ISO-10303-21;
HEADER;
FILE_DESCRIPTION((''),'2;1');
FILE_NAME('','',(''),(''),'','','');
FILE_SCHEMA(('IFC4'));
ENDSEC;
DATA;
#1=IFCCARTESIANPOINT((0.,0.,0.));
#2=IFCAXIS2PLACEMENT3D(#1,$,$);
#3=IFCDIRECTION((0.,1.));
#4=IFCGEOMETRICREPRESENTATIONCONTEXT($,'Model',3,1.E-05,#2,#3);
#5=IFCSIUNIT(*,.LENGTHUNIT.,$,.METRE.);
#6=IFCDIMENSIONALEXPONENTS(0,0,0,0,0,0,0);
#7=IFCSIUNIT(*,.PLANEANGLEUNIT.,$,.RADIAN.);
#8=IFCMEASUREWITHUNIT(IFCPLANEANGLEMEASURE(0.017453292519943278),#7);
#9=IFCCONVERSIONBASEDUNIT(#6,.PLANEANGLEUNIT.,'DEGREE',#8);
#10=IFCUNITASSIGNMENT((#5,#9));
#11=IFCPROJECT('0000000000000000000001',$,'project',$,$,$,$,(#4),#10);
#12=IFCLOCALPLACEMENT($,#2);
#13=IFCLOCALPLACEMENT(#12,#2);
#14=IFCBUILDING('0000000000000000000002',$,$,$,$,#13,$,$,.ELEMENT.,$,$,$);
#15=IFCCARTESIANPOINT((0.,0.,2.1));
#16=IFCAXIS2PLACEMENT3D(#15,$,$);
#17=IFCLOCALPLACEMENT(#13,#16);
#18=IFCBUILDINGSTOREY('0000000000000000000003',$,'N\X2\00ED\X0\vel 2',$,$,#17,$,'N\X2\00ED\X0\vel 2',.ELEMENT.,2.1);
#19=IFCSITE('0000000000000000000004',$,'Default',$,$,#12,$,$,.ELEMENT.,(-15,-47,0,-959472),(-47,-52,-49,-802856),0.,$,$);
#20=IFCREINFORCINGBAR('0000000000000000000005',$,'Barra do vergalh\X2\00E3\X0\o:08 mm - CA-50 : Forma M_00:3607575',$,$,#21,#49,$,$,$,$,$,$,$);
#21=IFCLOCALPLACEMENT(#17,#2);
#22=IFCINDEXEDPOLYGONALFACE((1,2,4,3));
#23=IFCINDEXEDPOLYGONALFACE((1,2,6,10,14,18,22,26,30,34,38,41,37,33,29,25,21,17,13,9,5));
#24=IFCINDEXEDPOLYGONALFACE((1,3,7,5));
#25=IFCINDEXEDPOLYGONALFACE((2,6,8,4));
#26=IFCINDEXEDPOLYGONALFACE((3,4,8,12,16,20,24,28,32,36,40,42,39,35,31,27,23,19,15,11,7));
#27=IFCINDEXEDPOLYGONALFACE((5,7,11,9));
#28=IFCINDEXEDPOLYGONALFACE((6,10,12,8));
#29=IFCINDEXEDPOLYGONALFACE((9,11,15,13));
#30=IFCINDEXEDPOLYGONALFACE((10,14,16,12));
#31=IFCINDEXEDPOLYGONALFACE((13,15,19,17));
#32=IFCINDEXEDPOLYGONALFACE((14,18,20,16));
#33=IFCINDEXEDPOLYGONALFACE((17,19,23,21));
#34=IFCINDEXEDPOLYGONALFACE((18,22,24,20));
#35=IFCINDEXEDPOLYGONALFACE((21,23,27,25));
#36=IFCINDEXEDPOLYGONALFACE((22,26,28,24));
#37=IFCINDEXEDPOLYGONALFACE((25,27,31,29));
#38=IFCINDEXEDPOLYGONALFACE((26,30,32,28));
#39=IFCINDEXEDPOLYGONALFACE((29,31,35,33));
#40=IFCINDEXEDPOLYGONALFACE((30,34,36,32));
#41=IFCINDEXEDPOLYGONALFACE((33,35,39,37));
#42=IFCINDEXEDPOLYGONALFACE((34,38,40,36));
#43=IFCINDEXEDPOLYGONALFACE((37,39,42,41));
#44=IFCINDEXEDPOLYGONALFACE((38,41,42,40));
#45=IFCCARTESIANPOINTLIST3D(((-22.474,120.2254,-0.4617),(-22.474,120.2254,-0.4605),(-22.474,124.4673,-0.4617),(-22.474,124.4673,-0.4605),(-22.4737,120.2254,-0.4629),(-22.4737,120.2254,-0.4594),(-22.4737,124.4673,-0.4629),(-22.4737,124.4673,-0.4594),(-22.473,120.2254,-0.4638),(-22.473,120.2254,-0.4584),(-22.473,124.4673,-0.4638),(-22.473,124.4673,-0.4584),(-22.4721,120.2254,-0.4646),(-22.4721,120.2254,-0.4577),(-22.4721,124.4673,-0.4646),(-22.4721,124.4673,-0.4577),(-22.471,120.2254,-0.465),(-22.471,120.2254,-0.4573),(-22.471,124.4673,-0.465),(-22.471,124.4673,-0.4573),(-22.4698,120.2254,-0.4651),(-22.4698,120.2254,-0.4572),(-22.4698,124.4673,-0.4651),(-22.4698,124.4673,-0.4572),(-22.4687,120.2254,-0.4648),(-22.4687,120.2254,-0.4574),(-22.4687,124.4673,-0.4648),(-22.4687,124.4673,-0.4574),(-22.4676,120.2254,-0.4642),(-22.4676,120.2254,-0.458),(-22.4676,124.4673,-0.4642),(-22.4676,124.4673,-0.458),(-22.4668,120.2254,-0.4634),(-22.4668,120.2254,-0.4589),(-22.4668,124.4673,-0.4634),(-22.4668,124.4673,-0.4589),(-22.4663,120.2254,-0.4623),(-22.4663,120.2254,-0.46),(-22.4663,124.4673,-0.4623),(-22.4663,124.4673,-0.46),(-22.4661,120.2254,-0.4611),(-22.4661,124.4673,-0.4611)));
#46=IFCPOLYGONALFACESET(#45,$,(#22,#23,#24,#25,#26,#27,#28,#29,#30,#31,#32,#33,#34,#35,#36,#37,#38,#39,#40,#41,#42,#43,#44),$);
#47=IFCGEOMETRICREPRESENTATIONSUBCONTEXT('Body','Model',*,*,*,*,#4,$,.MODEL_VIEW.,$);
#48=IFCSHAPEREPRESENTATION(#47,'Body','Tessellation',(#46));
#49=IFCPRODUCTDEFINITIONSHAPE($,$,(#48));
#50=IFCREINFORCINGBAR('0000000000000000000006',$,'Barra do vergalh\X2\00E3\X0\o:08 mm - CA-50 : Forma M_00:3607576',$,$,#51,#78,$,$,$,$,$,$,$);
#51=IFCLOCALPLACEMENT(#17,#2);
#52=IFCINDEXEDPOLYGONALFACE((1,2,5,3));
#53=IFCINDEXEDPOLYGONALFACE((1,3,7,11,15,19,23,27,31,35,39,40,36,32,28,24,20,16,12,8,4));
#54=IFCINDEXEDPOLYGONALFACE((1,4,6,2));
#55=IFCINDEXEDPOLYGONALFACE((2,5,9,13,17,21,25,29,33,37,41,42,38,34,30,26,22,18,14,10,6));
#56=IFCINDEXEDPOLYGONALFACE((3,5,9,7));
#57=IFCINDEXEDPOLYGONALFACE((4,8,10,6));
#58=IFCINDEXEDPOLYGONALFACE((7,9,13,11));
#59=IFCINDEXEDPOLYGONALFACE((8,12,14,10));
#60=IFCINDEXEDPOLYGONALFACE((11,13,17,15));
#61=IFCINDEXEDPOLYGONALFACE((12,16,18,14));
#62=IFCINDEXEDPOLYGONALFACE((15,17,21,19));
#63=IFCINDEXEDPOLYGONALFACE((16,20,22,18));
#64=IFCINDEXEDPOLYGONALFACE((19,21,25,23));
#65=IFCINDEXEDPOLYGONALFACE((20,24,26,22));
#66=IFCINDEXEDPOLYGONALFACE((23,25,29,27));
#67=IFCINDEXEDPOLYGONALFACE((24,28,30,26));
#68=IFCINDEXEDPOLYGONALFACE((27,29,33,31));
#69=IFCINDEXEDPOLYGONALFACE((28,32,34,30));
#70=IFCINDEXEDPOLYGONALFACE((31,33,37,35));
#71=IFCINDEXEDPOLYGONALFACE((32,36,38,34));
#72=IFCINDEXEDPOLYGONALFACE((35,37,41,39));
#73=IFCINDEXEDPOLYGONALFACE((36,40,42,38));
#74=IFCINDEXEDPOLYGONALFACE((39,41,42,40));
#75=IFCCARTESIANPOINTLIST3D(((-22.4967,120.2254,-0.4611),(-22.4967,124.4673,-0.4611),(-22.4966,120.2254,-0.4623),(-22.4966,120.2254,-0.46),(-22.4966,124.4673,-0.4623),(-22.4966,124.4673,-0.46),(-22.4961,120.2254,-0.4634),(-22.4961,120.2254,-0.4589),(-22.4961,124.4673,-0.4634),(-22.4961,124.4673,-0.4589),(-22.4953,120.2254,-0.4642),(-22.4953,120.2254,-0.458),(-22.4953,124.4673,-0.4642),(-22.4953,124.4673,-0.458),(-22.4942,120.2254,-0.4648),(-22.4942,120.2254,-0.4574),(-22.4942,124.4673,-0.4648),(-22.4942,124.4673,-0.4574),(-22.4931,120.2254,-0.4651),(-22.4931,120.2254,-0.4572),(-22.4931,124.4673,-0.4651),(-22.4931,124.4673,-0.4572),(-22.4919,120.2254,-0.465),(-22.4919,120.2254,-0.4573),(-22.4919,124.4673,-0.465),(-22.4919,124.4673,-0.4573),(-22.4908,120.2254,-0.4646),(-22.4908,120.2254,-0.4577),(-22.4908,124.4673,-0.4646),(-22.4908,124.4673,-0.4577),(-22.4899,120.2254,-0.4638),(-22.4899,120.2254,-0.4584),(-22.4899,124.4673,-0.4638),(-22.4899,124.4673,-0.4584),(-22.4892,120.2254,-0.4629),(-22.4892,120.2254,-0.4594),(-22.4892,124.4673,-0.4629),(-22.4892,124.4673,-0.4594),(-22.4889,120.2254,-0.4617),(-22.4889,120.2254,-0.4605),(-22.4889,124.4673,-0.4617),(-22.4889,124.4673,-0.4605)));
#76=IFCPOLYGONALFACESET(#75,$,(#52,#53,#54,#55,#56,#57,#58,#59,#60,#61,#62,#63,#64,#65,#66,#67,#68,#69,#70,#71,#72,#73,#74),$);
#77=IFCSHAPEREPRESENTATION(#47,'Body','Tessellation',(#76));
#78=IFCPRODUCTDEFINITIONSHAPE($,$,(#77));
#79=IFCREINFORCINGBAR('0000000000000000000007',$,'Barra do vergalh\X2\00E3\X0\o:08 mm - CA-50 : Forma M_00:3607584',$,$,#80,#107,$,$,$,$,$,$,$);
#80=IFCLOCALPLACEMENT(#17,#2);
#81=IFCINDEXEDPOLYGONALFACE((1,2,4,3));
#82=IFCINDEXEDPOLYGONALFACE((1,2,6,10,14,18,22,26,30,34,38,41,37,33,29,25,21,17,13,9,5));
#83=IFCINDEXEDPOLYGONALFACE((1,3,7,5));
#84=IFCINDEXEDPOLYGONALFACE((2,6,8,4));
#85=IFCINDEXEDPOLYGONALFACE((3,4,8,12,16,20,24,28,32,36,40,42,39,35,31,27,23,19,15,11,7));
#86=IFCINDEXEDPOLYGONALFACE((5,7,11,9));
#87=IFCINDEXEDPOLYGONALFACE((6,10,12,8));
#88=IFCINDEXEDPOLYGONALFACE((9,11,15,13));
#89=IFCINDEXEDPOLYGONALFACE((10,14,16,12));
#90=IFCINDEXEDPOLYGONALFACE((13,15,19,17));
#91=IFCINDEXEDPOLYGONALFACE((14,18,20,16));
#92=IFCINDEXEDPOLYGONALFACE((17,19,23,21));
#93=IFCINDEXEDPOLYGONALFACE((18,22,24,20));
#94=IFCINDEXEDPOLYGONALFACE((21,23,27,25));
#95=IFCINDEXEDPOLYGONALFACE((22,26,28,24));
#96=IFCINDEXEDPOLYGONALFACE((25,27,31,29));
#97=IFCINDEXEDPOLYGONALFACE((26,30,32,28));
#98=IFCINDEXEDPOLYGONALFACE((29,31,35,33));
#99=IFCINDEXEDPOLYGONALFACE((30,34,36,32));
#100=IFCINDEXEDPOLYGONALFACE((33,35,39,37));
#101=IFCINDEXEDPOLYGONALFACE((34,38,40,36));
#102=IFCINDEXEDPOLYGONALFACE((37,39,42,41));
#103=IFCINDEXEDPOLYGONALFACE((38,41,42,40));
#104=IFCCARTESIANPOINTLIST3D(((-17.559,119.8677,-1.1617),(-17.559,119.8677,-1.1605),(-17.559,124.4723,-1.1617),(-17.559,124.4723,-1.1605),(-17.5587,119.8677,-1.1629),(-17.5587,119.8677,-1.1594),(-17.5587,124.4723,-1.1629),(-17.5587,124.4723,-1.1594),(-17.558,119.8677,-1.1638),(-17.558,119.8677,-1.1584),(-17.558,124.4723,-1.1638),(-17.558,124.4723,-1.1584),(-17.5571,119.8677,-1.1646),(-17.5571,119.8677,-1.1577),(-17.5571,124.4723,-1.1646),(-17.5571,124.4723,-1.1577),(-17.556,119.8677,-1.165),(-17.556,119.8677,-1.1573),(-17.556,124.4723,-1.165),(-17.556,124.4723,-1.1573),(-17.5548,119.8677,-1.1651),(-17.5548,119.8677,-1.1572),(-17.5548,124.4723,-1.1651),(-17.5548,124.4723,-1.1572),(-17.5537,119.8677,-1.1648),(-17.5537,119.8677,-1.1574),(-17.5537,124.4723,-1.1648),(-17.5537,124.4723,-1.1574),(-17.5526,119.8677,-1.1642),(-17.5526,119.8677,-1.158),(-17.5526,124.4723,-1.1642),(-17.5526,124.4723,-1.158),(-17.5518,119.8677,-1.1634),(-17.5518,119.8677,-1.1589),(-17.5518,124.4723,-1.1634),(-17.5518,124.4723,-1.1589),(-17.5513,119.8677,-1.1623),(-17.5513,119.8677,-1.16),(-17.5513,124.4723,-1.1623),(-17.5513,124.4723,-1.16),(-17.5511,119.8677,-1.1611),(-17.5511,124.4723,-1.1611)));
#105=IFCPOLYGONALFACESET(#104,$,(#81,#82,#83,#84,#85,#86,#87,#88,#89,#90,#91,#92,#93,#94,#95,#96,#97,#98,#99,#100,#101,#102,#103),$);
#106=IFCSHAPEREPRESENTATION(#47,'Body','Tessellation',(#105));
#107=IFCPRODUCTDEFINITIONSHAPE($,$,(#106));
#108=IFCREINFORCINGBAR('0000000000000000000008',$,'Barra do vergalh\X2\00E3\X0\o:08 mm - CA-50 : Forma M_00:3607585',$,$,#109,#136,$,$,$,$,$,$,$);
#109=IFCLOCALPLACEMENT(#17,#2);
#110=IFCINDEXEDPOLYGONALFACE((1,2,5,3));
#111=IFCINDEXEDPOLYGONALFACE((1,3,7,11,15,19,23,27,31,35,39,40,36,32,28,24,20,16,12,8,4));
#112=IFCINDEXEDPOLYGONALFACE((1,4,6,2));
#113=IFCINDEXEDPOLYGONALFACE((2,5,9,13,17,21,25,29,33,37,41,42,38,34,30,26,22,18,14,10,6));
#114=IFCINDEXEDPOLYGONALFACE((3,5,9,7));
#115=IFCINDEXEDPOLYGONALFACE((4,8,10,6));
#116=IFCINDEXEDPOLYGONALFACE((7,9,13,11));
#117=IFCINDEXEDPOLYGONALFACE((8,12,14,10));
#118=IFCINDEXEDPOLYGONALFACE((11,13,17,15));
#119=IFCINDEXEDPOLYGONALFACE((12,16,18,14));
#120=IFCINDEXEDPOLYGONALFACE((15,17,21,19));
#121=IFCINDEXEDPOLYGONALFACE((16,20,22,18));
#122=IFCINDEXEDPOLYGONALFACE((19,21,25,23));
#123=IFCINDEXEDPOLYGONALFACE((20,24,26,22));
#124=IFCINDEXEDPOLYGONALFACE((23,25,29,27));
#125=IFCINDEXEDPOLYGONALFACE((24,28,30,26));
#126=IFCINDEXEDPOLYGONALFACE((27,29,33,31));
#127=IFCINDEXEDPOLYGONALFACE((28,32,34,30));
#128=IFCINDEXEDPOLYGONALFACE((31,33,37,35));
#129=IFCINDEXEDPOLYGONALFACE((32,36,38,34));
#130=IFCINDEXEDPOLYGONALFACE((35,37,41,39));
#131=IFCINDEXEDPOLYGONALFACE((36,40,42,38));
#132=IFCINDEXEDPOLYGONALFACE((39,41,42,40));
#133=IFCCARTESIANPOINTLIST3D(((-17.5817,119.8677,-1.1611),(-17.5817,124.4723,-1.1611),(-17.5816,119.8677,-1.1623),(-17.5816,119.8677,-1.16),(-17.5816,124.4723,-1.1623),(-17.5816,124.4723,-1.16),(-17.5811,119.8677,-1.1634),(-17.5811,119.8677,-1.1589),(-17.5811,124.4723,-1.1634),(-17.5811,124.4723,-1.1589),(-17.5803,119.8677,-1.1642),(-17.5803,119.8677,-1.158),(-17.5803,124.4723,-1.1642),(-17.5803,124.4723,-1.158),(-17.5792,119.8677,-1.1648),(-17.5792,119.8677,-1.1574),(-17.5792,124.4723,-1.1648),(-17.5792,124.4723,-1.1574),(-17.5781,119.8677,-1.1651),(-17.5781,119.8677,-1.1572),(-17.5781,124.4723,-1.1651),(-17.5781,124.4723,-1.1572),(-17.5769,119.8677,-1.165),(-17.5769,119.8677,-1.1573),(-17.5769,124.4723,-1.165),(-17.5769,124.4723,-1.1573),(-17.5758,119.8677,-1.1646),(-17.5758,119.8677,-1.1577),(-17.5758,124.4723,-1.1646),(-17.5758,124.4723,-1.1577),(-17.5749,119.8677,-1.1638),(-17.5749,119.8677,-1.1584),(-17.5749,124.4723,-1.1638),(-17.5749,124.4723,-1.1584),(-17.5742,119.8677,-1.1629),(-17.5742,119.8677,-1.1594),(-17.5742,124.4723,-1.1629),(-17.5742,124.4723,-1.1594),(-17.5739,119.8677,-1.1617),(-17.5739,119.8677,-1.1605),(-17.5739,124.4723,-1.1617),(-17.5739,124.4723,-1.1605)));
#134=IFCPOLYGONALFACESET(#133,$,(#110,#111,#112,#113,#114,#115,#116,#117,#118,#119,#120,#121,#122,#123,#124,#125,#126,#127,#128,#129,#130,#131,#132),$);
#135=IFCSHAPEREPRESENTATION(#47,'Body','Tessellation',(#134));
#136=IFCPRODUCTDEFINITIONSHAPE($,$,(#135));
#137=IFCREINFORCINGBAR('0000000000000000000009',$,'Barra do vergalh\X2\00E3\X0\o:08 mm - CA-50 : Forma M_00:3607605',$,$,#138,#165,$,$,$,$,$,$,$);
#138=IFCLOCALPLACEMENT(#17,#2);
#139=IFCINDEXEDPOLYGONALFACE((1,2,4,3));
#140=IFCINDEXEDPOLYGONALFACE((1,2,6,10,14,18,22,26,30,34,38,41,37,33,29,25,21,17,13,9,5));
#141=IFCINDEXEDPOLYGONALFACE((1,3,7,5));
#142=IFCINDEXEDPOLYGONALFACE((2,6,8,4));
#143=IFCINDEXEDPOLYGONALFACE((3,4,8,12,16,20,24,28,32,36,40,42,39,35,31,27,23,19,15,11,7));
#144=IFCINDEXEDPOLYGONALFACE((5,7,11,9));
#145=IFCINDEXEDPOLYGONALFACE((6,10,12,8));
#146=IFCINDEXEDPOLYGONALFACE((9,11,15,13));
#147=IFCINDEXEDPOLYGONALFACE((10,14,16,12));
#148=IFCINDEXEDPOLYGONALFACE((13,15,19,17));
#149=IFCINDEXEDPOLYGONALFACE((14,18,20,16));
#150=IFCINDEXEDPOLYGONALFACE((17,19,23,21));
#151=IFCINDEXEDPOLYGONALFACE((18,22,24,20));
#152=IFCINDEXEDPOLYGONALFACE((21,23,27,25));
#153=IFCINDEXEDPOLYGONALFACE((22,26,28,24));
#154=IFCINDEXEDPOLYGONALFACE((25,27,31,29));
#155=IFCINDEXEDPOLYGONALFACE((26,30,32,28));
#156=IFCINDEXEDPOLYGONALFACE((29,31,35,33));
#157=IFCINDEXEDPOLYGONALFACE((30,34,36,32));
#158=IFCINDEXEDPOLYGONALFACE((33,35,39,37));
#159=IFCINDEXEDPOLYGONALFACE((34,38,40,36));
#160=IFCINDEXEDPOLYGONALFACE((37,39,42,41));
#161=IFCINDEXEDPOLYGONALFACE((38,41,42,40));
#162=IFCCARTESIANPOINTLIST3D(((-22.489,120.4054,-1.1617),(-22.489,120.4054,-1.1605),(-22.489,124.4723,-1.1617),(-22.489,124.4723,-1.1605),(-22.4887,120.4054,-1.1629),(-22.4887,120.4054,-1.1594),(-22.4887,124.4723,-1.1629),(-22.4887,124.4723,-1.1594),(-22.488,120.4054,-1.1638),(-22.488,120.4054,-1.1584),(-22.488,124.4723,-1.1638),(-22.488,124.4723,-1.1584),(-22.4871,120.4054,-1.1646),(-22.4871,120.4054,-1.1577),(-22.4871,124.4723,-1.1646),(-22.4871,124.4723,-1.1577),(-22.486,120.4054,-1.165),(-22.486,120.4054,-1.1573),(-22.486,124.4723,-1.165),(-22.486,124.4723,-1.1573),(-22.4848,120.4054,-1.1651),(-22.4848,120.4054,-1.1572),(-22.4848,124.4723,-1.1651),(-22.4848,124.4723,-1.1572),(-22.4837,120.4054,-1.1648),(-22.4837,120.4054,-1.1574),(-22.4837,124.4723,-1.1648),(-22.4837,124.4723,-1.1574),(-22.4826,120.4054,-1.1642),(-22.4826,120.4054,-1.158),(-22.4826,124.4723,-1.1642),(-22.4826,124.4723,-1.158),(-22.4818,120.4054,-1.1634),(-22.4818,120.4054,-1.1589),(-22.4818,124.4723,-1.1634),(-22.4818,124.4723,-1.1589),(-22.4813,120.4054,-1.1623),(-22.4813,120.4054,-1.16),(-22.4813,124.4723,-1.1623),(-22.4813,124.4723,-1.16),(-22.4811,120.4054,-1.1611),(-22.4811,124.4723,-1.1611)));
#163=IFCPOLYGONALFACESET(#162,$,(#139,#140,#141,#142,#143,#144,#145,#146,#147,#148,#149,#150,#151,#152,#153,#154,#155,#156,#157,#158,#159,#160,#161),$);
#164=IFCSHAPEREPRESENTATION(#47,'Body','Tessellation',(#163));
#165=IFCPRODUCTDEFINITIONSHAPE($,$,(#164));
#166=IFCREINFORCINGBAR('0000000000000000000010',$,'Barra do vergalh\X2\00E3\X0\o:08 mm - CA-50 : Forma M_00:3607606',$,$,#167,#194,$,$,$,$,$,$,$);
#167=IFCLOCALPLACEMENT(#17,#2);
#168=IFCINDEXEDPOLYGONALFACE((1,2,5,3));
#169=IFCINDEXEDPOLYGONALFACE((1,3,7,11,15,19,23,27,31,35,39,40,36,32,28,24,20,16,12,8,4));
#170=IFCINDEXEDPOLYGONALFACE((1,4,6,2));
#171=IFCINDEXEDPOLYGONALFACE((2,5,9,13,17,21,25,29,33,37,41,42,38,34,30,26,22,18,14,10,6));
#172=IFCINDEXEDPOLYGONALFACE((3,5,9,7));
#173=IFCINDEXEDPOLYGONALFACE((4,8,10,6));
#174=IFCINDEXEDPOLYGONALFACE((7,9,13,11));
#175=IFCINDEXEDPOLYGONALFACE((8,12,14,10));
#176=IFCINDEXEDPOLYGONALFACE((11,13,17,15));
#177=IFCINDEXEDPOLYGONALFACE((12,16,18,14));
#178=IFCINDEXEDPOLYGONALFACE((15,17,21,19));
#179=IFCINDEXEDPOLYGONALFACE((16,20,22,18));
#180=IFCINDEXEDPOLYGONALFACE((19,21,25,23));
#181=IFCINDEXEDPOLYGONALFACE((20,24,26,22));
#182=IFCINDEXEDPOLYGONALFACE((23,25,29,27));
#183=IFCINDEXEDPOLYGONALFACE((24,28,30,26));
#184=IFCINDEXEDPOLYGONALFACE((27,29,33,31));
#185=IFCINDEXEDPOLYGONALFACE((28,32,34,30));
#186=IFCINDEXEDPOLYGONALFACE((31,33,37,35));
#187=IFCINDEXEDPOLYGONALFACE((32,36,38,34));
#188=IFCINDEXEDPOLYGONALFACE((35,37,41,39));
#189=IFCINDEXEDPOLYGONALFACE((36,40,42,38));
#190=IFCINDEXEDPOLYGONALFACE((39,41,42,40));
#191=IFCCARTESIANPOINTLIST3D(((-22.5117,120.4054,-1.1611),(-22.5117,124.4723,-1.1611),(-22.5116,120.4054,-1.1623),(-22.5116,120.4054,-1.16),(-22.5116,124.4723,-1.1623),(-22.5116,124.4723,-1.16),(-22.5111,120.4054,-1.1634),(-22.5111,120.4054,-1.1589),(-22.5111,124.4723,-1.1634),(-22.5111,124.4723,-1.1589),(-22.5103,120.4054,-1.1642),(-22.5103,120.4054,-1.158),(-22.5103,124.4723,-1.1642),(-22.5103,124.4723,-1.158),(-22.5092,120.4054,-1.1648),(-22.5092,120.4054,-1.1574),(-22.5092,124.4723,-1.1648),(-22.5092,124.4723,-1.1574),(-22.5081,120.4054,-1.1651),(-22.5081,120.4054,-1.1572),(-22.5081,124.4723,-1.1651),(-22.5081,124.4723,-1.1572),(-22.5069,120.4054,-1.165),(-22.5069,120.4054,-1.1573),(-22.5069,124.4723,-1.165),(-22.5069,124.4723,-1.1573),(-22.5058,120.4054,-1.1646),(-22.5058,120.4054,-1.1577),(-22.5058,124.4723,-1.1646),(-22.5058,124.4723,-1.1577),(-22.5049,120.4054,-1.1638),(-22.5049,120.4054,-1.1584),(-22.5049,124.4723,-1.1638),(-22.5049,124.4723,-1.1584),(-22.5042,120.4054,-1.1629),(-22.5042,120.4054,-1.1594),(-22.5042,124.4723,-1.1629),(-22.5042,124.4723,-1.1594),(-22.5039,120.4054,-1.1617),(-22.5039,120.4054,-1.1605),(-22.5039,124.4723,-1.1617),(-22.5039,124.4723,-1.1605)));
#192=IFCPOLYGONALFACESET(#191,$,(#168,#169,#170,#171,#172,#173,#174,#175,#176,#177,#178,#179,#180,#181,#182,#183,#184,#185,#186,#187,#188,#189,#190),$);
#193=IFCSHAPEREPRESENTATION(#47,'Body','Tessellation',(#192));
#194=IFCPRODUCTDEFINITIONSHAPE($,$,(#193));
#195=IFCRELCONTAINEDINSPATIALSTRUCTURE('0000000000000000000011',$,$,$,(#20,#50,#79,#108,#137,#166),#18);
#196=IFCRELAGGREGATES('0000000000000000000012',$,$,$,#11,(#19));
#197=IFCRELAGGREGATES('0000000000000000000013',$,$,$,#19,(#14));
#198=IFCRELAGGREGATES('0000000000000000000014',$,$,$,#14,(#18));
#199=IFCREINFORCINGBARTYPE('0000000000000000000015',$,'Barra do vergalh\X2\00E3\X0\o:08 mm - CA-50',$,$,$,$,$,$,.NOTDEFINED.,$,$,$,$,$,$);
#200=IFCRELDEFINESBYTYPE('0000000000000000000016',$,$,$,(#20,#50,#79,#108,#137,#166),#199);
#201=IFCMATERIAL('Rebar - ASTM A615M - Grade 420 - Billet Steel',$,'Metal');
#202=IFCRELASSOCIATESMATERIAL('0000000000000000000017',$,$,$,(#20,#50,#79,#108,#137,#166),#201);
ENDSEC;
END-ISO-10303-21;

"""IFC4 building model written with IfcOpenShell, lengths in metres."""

from ifc_helpers import new_model, entity, si_unit, converted_unit, direction, frame, origin, place, context, subcontext, project, spatial, material, type_object, element, save


model = new_model("IFC4")

# Units and contexts
model_context = context("Model", 3, precision=1e-05, world=origin(), true_north=direction((0.0, 1.0)))
body_context = subcontext(model_context, "Body", "Model", "MODEL_VIEW")
ifc_project = project(units=[si_unit("LENGTHUNIT", "METRE"), converted_unit("PLANEANGLEUNIT", "DEGREE", entity("IfcPlaneAngleMeasure", 0.017453292519943278), si_unit("PLANEANGLEUNIT", "RADIAN"), dimensions=[0, 0, 0, 0, 0, 0, 0])], contexts=[model_context])

# Site, building, storey
site_placement = place(None, origin())
site = spatial("IfcSite", under=ifc_project, at=site_placement, Name="Default", CompositionType="ELEMENT", RefLatitude=(-15, -47, 0, -959472), RefLongitude=(-47, -52, -49, -802856), RefElevation=0.0)
building_placement = place(site_placement, origin())
building = spatial("IfcBuilding", under=site, at=building_placement, CompositionType="ELEMENT")
storey_placement = place(building_placement, frame((0.0, 0.0, 2.1)))
storey = spatial("IfcBuildingStorey", under=building, at=storey_placement, Name="Nível 2", LongName="Nível 2", CompositionType="ELEMENT", Elevation=2.1)

# Reinforcing bars
ifc_material = material(Name="Rebar - ASTM A615M - Grade 420 - Billet Steel", Category="Metal")
reinforcing_bar_type_1 = type_object("IfcReinforcingBarType", Name="Barra do vergalhão:08 mm - CA-50", PredefinedType="NOTDEFINED")
reinforcing_bar_1_placement = place(storey_placement, origin())
element("IfcReinforcingBar", 1, at=reinforcing_bar_1_placement, inside=storey, type_object=reinforcing_bar_type_1, material=ifc_material, Name="Barra do vergalhão:08 mm - CA-50 : Forma M_00:3607575", context=body_context, shape_type="AdvancedSweptSolid", body=[
    entity("IfcSweptDiskSolid", entity("IfcIndexedPolyCurve", entity("IfcCartesianPointList3D", [[22.4701, -124.4673, 0.4611], [22.4701, -120.2254, 0.4611]]), None, False), 0.004, None, 0.0, 1.0),
])
reinforcing_bar_2_placement = place(storey_placement, origin())
element("IfcReinforcingBar", 2, at=reinforcing_bar_2_placement, inside=storey, type_object=reinforcing_bar_type_1, material=ifc_material, Name="Barra do vergalhão:08 mm - CA-50 : Forma M_00:3607576", context=body_context, shape_type="AdvancedSweptSolid", body=[
    entity("IfcSweptDiskSolid", entity("IfcIndexedPolyCurve", entity("IfcCartesianPointList3D", [[22.4928, -120.2254, 0.4611], [22.4928, -124.4673, 0.4611]]), None, False), 0.004, None, 0.0, 1.0),
])
reinforcing_bar_3_placement = place(storey_placement, origin())
element("IfcReinforcingBar", 3, at=reinforcing_bar_3_placement, inside=storey, type_object=reinforcing_bar_type_1, material=ifc_material, Name="Barra do vergalhão:08 mm - CA-50 : Forma M_00:3607584", context=body_context, shape_type="AdvancedSweptSolid", body=[
    entity("IfcSweptDiskSolid", entity("IfcIndexedPolyCurve", entity("IfcCartesianPointList3D", [[17.5551, -124.4723, 1.1611], [17.5551, -119.8677, 1.1611]]), None, False), 0.004, None, 0.0, 1.0),
])
reinforcing_bar_4_placement = place(storey_placement, origin())
element("IfcReinforcingBar", 4, at=reinforcing_bar_4_placement, inside=storey, type_object=reinforcing_bar_type_1, material=ifc_material, Name="Barra do vergalhão:08 mm - CA-50 : Forma M_00:3607585", context=body_context, shape_type="AdvancedSweptSolid", body=[
    entity("IfcSweptDiskSolid", entity("IfcIndexedPolyCurve", entity("IfcCartesianPointList3D", [[17.5778, -119.8677, 1.1611], [17.5778, -124.4723, 1.1611]]), None, False), 0.004, None, 0.0, 1.0),
])
reinforcing_bar_5_placement = place(storey_placement, origin())
element("IfcReinforcingBar", 5, at=reinforcing_bar_5_placement, inside=storey, type_object=reinforcing_bar_type_1, material=ifc_material, Name="Barra do vergalhão:08 mm - CA-50 : Forma M_00:3607605", context=body_context, shape_type="AdvancedSweptSolid", body=[
    entity("IfcSweptDiskSolid", entity("IfcIndexedPolyCurve", entity("IfcCartesianPointList3D", [[22.4851, -124.4723, 1.1611], [22.4851, -120.4054, 1.1611]]), None, False), 0.004, None, 0.0, 1.0),
])
reinforcing_bar_6_placement = place(storey_placement, origin())
element("IfcReinforcingBar", 6, at=reinforcing_bar_6_placement, inside=storey, type_object=reinforcing_bar_type_1, material=ifc_material, Name="Barra do vergalhão:08 mm - CA-50 : Forma M_00:3607606", context=body_context, shape_type="AdvancedSweptSolid", body=[
    entity("IfcSweptDiskSolid", entity("IfcIndexedPolyCurve", entity("IfcCartesianPointList3D", [[22.5078, -120.4054, 1.1611], [22.5078, -124.4723, 1.1611]]), None, False), 0.004, None, 0.0, 1.0),
])

save(model, "model.ifc")
